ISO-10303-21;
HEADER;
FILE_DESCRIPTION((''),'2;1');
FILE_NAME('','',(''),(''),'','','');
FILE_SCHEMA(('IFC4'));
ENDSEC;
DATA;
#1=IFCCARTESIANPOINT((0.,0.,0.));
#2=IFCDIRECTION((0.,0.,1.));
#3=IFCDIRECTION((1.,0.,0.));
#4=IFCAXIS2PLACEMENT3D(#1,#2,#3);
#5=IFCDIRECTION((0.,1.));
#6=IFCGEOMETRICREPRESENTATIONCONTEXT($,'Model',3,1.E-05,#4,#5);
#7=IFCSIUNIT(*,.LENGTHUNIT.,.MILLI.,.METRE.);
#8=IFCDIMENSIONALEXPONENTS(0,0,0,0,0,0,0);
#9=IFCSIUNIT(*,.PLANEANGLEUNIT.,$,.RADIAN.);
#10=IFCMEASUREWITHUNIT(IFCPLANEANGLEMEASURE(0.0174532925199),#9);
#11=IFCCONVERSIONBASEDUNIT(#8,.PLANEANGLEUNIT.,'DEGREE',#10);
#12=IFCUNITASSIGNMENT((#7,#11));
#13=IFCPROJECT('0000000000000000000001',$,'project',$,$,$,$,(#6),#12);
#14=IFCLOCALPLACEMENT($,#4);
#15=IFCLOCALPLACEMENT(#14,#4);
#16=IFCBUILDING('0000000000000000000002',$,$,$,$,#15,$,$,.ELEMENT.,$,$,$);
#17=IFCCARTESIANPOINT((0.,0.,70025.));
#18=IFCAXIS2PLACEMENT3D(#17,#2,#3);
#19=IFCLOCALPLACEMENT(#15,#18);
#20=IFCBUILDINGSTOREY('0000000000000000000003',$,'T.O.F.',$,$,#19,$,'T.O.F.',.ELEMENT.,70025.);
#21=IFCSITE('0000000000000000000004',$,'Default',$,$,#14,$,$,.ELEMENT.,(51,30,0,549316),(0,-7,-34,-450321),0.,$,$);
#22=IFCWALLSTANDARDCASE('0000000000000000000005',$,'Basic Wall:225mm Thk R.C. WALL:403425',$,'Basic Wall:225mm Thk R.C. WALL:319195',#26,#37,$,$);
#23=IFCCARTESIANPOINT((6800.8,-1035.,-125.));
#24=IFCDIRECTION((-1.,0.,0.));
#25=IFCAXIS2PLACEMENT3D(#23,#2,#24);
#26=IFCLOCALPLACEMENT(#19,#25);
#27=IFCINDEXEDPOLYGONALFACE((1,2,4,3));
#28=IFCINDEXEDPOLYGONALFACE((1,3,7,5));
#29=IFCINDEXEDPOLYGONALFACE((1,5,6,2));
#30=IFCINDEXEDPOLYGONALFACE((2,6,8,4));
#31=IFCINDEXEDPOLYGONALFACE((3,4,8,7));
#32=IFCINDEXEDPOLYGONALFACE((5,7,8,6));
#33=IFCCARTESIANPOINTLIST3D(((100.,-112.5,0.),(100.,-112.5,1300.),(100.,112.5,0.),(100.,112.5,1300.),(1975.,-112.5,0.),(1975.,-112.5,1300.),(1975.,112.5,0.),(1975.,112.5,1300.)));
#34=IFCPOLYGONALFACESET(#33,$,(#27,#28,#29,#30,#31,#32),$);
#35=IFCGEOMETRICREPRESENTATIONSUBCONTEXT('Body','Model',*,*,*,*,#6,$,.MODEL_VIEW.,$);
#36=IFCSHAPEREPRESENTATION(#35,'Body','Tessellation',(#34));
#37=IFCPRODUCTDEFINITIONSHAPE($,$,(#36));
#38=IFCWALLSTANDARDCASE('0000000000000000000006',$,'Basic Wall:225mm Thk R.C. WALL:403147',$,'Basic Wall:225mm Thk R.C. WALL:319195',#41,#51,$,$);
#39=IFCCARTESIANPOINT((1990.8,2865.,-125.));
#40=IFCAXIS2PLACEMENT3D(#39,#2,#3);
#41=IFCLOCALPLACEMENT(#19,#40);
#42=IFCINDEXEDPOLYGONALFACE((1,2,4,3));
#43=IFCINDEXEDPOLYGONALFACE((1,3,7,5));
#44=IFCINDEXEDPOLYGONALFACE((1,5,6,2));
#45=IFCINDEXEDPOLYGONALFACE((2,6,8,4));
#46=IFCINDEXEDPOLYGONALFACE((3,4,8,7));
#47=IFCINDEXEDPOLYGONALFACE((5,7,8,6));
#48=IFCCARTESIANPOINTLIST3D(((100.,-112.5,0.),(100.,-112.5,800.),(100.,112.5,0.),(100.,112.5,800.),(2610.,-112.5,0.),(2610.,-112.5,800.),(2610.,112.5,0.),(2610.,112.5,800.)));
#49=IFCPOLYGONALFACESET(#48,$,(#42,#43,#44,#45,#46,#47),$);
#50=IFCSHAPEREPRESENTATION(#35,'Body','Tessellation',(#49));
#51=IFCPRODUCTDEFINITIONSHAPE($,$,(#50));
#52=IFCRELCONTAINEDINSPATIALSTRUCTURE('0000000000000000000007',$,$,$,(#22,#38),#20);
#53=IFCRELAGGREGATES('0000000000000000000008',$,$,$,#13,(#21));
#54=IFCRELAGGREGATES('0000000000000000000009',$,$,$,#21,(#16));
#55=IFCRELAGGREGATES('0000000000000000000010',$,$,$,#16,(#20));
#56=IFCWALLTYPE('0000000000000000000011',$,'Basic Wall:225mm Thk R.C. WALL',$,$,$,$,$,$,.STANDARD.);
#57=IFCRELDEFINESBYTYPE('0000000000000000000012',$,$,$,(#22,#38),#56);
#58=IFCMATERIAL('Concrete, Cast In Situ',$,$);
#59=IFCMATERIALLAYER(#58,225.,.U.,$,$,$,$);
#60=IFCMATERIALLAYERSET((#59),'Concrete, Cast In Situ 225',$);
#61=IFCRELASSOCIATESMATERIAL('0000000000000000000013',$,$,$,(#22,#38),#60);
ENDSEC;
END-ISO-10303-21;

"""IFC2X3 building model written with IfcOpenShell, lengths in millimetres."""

from ifc_helpers import new_model, entity, si_unit, converted_unit, direction, frame, origin_with_axes, place, context, subcontext, project, spatial, polyline, outline, extrude, material, layer, layer_set, layer_usage, type_object, element, save


model = new_model("IFC2X3")

# Units and contexts
model_context = context("Model", 3, precision=1e-05, world=origin_with_axes(), true_north=direction((0.0, 1.0)))
body_context = subcontext(model_context, "Body", "Model", "MODEL_VIEW")
ifc_project = project(units=[si_unit("LENGTHUNIT", "METRE", prefix="MILLI"), converted_unit("PLANEANGLEUNIT", "DEGREE", entity("IfcPlaneAngleMeasure", 0.0174532925199), si_unit("PLANEANGLEUNIT", "RADIAN"), dimensions=[0, 0, 0, 0, 0, 0, 0])], contexts=[model_context])

# Site, building, storey
site_placement = place(None, origin_with_axes())
site = spatial("IfcSite", under=ifc_project, at=site_placement, Name="Default", CompositionType="ELEMENT", RefLatitude=(51, 30, 0, 549316), RefLongitude=(0, -7, -34, -450321), RefElevation=0.0)
building_placement = place(site_placement, origin_with_axes())
building = spatial("IfcBuilding", under=site, at=building_placement, CompositionType="ELEMENT")
storey_placement = place(building_placement, frame((0.0, 0.0, 70025.0), z_axis=(0.0, 0.0, 1.0), x_axis=(1.0, 0.0, 0.0)))
storey = spatial("IfcBuildingStorey", under=building, at=storey_placement, Name="T.O.F.", LongName="T.O.F.", CompositionType="ELEMENT", Elevation=70025.0)

# Wall
ifc_material_1 = material(Name="Concrete, Cast In Situ")
ifc_layer_1 = layer(ifc_material_1, 225.0, ventilated="UNKNOWN")
ifc_layer_set_1 = layer_set([ifc_layer_1], Name="Concrete, Cast In Situ 225")
ifc_layer_usage_1 = layer_usage(ifc_layer_set_1, "AXIS2", "POSITIVE", -112.5)
wall_type_1 = type_object("IfcWallType", Name="Basic Wall:225mm Thk R.C. WALL", PredefinedType="STANDARD")
wall_1_placement = place(storey_placement, frame((6800.8, -1035.0, -125.0), z_axis=(0.0, 0.0, 1.0), x_axis=(-1.0, 0.0, 0.0)))
element("IfcWallStandardCase", 1, at=wall_1_placement, inside=storey, type_object=wall_type_1, material=ifc_layer_usage_1, Name="Basic Wall:225mm Thk R.C. WALL:403425", ObjectType="Basic Wall:225mm Thk R.C. WALL:319195", context=body_context, shape_type="SweptSolid", body=[
    extrude(outline(polyline([(100.0, -112.5), (1975.0, -112.5), (1975.0, 112.5), (100.0, 112.5), (100.0, -112.5)])), origin_with_axes(), (0.0, 0.0, 1.0), 1300.0),
])

# Wall
ifc_layer_usage_2 = layer_usage(ifc_layer_set_1, "AXIS2", "POSITIVE", -112.5)
wall_2_placement = place(storey_placement, frame((1990.8, 2865.0, -125.0), z_axis=(0.0, 0.0, 1.0), x_axis=(1.0, 0.0, 0.0)))
element("IfcWallStandardCase", 2, at=wall_2_placement, inside=storey, type_object=wall_type_1, material=ifc_layer_usage_2, Name="Basic Wall:225mm Thk R.C. WALL:403147", ObjectType="Basic Wall:225mm Thk R.C. WALL:319195", context=body_context, shape_type="SweptSolid", body=[
    extrude(outline(polyline([(100.0, -112.5), (2610.0, -112.5), (2610.0, 112.5), (100.0, 112.5), (100.0, -112.5)])), origin_with_axes(), (0.0, 0.0, 1.0), 800.0),
])

save(model, "model.ifc")
